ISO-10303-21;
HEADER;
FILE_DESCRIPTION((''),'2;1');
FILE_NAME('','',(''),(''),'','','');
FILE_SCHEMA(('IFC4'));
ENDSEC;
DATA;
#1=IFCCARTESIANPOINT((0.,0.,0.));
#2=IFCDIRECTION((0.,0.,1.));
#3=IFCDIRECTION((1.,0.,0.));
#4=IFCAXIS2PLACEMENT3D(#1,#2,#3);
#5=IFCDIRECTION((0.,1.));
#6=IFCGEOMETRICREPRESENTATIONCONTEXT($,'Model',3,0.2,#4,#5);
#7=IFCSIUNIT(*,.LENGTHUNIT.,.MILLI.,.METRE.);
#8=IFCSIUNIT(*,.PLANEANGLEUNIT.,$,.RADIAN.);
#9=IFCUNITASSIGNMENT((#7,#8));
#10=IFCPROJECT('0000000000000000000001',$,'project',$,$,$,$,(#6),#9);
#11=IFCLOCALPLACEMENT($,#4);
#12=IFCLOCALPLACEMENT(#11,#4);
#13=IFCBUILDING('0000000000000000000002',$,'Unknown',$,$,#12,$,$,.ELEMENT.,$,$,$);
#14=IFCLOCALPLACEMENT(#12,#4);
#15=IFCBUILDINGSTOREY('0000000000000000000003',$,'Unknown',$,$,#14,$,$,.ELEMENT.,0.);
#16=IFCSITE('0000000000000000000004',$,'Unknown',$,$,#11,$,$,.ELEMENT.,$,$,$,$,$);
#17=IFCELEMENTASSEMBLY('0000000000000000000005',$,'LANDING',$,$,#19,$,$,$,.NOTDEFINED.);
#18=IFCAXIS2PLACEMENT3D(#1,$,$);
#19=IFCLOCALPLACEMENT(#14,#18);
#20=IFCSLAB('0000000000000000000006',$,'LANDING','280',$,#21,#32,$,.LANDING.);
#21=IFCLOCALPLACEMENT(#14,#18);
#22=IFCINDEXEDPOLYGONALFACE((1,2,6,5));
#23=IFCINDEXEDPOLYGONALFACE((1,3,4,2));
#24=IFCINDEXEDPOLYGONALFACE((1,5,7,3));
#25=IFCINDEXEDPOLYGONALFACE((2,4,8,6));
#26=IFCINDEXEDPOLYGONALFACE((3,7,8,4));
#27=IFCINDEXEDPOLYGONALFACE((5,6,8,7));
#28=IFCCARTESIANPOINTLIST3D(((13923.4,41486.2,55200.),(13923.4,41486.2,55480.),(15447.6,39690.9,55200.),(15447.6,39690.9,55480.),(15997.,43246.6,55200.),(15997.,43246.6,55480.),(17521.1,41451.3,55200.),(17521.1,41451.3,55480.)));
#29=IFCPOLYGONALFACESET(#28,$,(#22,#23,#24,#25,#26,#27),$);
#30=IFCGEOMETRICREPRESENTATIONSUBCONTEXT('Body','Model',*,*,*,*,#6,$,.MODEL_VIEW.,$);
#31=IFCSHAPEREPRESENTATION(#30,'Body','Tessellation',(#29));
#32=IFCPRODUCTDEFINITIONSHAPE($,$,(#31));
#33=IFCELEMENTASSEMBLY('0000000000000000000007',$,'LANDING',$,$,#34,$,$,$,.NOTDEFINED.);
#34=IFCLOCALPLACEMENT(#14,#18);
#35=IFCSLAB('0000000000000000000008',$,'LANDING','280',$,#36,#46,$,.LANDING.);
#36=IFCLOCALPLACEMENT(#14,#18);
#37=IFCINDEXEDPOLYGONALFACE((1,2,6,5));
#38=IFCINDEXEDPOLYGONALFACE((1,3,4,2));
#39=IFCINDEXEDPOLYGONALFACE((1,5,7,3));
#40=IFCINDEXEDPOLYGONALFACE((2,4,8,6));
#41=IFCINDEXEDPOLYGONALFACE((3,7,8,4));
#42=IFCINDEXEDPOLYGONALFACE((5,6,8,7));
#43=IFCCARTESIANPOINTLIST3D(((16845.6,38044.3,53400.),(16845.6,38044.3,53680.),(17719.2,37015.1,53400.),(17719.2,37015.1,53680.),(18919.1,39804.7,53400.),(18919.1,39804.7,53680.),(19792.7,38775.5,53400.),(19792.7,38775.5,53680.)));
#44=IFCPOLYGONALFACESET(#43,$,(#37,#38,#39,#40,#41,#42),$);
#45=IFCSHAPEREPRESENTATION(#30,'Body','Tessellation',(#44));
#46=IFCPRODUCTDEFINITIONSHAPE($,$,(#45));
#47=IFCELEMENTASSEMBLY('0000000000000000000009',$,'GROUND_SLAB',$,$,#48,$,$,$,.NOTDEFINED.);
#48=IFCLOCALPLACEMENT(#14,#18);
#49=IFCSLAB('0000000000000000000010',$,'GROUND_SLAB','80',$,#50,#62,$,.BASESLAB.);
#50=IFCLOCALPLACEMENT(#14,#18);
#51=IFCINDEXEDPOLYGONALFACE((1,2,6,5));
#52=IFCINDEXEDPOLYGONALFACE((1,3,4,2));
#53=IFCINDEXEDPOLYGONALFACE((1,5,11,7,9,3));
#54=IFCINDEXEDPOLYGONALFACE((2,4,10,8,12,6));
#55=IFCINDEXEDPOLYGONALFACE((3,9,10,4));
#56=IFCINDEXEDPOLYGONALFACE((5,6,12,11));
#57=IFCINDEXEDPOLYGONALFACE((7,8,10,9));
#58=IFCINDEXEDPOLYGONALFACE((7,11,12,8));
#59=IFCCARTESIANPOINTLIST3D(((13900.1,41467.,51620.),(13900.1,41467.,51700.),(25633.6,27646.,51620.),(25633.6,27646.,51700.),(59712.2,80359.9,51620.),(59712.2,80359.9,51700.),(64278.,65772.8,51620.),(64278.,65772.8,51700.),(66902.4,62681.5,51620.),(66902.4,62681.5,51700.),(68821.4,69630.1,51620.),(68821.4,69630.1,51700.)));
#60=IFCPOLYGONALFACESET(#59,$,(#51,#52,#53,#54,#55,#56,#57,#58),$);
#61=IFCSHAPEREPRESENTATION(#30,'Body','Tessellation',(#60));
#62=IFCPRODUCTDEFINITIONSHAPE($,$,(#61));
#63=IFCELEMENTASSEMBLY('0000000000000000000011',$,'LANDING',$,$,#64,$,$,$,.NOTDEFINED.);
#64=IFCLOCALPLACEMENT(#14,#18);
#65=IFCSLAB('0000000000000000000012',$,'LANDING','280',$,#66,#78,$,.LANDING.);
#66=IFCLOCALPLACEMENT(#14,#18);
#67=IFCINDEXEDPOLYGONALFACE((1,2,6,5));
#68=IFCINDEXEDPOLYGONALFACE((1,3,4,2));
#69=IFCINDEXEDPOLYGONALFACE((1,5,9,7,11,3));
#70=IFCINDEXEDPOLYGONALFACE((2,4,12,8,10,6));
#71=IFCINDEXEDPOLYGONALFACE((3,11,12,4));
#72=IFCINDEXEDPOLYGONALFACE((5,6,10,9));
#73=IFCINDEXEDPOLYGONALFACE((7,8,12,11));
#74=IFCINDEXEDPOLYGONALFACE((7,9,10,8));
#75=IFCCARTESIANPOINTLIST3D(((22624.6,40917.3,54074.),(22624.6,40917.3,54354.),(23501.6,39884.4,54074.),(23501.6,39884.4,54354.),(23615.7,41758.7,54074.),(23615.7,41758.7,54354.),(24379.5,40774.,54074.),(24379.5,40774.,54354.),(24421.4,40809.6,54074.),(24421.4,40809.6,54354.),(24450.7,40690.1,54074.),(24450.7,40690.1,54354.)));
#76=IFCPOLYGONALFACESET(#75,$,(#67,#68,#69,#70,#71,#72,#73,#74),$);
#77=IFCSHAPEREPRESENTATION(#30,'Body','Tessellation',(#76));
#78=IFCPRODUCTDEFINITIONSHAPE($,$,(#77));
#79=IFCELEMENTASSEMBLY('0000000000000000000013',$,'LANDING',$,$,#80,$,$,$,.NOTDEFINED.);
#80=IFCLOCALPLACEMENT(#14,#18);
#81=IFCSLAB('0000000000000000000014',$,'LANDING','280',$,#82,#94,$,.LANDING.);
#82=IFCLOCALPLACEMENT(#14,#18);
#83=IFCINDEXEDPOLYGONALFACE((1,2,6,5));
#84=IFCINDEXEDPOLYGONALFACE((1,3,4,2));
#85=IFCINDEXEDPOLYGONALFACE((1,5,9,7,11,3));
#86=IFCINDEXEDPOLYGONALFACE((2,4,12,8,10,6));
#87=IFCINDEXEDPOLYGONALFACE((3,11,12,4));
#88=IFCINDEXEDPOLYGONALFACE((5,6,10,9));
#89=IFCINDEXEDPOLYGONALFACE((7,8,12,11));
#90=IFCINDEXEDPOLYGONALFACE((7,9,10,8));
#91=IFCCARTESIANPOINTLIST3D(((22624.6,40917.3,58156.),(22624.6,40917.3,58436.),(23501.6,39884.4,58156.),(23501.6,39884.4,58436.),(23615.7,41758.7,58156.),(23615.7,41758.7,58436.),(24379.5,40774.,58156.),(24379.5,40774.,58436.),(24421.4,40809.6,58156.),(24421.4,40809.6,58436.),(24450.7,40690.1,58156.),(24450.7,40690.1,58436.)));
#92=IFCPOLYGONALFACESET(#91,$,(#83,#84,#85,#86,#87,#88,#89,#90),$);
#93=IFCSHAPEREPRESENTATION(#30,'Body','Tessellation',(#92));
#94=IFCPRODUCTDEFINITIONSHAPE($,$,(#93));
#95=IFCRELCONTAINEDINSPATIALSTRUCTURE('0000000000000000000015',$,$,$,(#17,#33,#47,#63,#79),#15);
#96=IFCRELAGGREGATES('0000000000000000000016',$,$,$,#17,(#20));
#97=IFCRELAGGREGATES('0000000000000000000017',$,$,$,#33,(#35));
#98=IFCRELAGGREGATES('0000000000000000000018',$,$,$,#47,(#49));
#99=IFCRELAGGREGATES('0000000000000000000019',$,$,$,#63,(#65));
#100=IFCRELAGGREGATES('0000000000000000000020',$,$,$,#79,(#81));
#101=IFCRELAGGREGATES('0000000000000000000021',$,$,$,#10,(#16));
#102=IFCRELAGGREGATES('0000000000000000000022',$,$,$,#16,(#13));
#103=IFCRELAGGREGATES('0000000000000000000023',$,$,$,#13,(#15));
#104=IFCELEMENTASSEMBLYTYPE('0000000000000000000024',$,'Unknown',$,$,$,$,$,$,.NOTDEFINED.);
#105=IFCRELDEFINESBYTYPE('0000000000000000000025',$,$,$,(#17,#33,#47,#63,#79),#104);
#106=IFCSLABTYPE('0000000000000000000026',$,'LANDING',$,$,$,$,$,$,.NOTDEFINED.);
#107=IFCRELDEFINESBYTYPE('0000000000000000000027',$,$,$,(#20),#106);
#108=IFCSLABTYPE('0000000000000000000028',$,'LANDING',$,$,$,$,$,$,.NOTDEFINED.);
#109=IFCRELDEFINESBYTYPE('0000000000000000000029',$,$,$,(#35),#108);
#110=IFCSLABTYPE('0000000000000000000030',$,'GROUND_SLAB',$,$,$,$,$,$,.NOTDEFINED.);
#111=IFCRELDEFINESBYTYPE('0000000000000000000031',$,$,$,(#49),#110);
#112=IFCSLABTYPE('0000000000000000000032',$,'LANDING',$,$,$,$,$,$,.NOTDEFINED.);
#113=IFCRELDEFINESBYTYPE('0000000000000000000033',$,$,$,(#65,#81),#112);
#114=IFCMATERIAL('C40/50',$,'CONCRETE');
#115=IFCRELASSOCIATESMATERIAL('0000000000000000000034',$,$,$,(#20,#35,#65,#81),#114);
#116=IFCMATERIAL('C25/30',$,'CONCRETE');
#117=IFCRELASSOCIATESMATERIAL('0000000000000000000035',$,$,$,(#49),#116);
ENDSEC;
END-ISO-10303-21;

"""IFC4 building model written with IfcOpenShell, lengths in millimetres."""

from ifc_helpers import new_model, si_unit, direction, frame, origin_with_axes, place, context, subcontext, project, spatial, line, indexed_curve, outline, extrude, material, material_profile, profile_set, profile_usage, type_object, element, aggregate, save


model = new_model("IFC4")

# Units and contexts
model_context = context("Model", 3, precision=0.2, world=origin_with_axes(), true_north=direction((0.0, 1.0)))
body_context = subcontext(model_context, "Body", "Model", "MODEL_VIEW")
ifc_project = project(units=[si_unit("LENGTHUNIT", "METRE", prefix="MILLI"), si_unit("PLANEANGLEUNIT", "RADIAN")], contexts=[model_context])

# Site, building, storey
site_placement = place(None, origin_with_axes())
site = spatial("IfcSite", under=ifc_project, at=site_placement, Name="Unknown", CompositionType="ELEMENT")
building_placement = place(site_placement, origin_with_axes())
building = spatial("IfcBuilding", under=site, at=building_placement, Name="Unknown", CompositionType="ELEMENT")
storey_placement = place(building_placement, origin_with_axes())
storey = spatial("IfcBuildingStorey", under=building, at=storey_placement, Name="Unknown", CompositionType="ELEMENT", Elevation=0.0)

# Shared definitions
element_assembly_type = type_object("IfcElementAssemblyType", Name="Unknown", PredefinedType="NOTDEFINED")
ifc_material_1 = material(Name="C40/50", Category="CONCRETE")

# Element assemblies, slabs
assembly_1_placement = place(storey_placement, frame((17521.1, 41451.3, 55340.0), z_axis=(0.0, 0.0, 1.0), x_axis=(-0.64719, 0.762329, 0.0)))
assembly_1 = element("IfcElementAssembly", 1, at=assembly_1_placement, inside=storey, type_object=element_assembly_type, Name="LANDING", PredefinedType="NOTDEFINED")
ifc_material_profile_1 = material_profile(ifc_material_1, outline(indexed_curve([(0.0, 0.0), (2355.0, 0.0), (2355.0, 2720.0), (0.0, 2720.0)], segments=[line(1, 2, 3, 4, 1)])), Name="280")
ifc_profile_set_1 = profile_set([ifc_material_profile_1])
ifc_profile_usage_1 = profile_usage(ifc_profile_set_1, cardinal=8)
slab_type_1 = type_object("IfcSlabType", Name="LANDING")
slab_1_placement = place(assembly_1_placement, origin_with_axes())
slab_1 = element("IfcSlab", 2, at=slab_1_placement, type_object=slab_type_1, material=ifc_profile_usage_1, Name="LANDING", Description="280", PredefinedType="LANDING", context=body_context, shape_type="SolidModel", body=[
    extrude(outline(indexed_curve([(0.0, 0.0), (2355.0, 0.0), (2355.0, 2720.0), (0.0, 2720.0)], segments=[line(1, 2, 3, 4, 1)])), frame((0.0, 0.0, 140.0), z_axis=(0.0, 0.0, 1.0), x_axis=(1.0, 0.0, 0.0)), (0.0, 0.0, -1.0), 280.0),
])
aggregate(assembly_1, [slab_1])
assembly_2_placement = place(storey_placement, frame((17719.2, 37015.1, 53540.0), z_axis=(0.0, 0.0, 1.0), x_axis=(0.762329, 0.64719, 0.0)))
assembly_2 = element("IfcElementAssembly", 3, at=assembly_2_placement, inside=storey, type_object=element_assembly_type, Name="LANDING", PredefinedType="NOTDEFINED")
ifc_material_profile_2 = material_profile(ifc_material_1, outline(indexed_curve([(0.0, 0.0), (2720.0, 0.0), (2720.1, 1350.0), (0.1, 1350.0)], segments=[line(1, 2, 3, 4, 1)])), Name="280")
ifc_profile_set_2 = profile_set([ifc_material_profile_2])
ifc_profile_usage_2 = profile_usage(ifc_profile_set_2, cardinal=8)
slab_type_2 = type_object("IfcSlabType", Name="LANDING")
slab_2_placement = place(assembly_2_placement, origin_with_axes())
slab_2 = element("IfcSlab", 4, at=slab_2_placement, type_object=slab_type_2, material=ifc_profile_usage_2, Name="LANDING", Description="280", PredefinedType="LANDING", context=body_context, shape_type="SolidModel", body=[
    extrude(outline(indexed_curve([(0.0, 0.0), (2720.0, 0.0), (2720.1, 1350.0), (0.1, 1350.0)], segments=[line(1, 2, 3, 4, 1)])), frame((0.0, 0.0, 140.0), z_axis=(0.0, 0.0, 1.0), x_axis=(1.0, 0.0, 0.0)), (0.0, 0.0, -1.0), 280.0),
])
aggregate(assembly_2, [slab_2])
assembly_3_placement = place(storey_placement, frame((13900.1, 41467.0, 51660.0), z_axis=(0.0, 0.0, 1.0), x_axis=(0.64719, -0.762329, 0.0)))
assembly_3 = element("IfcElementAssembly", 5, at=assembly_3_placement, inside=storey, type_object=element_assembly_type, Name="GROUND_SLAB", PredefinedType="NOTDEFINED")
ifc_material_2 = material(Name="C25/30", Category="CONCRETE")
ifc_material_profile_3 = material_profile(ifc_material_2, outline(indexed_curve([(0.0, 0.0), (18130.0, 0.0), (18130.1, 54135.0), (14075.1, 54135.0), (14075.0, 60095.0), (0.0, 60095.0)], segments=[line(1, 2, 3, 4, 5, 6, 1)])), Name="80")
ifc_profile_set_3 = profile_set([ifc_material_profile_3])
ifc_profile_usage_3 = profile_usage(ifc_profile_set_3, cardinal=8)
slab_type_3 = type_object("IfcSlabType", Name="GROUND_SLAB")
slab_3_placement = place(assembly_3_placement, origin_with_axes())
slab_3 = element("IfcSlab", 6, at=slab_3_placement, type_object=slab_type_3, material=ifc_profile_usage_3, Name="GROUND_SLAB", Description="80", PredefinedType="BASESLAB", context=body_context, shape_type="SolidModel", body=[
    extrude(outline(indexed_curve([(0.0, 0.0), (18130.0, 0.0), (18130.1, 54135.0), (14075.1, 54135.0), (14075.0, 60095.0), (0.0, 60095.0)], segments=[line(1, 2, 3, 4, 5, 6, 1)])), frame((0.0, 0.0, 40.0), z_axis=(0.0, 0.0, 1.0), x_axis=(1.0, 0.0, 0.0)), (0.0, 0.0, -1.0), 80.0),
])
aggregate(assembly_3, [slab_3])
assembly_4_placement = place(storey_placement, frame((23615.7, 41758.7, 54214.0), z_axis=(0.0, 0.0, 1.0), x_axis=(-0.762329, -0.64719, 0.0)))
assembly_4 = element("IfcElementAssembly", 7, at=assembly_4_placement, inside=storey, type_object=element_assembly_type, Name="LANDING", PredefinedType="NOTDEFINED")
ifc_material_profile_4 = material_profile(ifc_material_1, outline(indexed_curve([(0.0, 0.0), (1300.0, 0.0), (1300.0, 1355.0), (55.0, 1355.0), (55.0, 1245.0), (0.0, 1245.0)], segments=[line(1, 2, 3, 4, 5, 6, 1)])), Name="280")
ifc_profile_set_4 = profile_set([ifc_material_profile_4])
ifc_profile_usage_4 = profile_usage(ifc_profile_set_4, cardinal=8)
slab_type_4 = type_object("IfcSlabType", Name="LANDING")
slab_4_placement = place(assembly_4_placement, origin_with_axes())
slab_4 = element("IfcSlab", 8, at=slab_4_placement, type_object=slab_type_4, material=ifc_profile_usage_4, Name="LANDING", Description="280", PredefinedType="LANDING", context=body_context, shape_type="SolidModel", body=[
    extrude(outline(indexed_curve([(0.0, 0.0), (1300.0, 0.0), (1300.0, 1355.0), (55.0, 1355.0), (55.0, 1245.0), (0.0, 1245.0)], segments=[line(1, 2, 3, 4, 5, 6, 1)])), frame((0.0, 0.0, 140.0), z_axis=(0.0, 0.0, 1.0), x_axis=(1.0, 0.0, 0.0)), (0.0, 0.0, -1.0), 280.0),
])
aggregate(assembly_4, [slab_4])
assembly_5_placement = place(storey_placement, frame((23615.7, 41758.7, 58296.0), z_axis=(0.0, 0.0, 1.0), x_axis=(-0.762329, -0.64719, 0.0)))
assembly_5 = element("IfcElementAssembly", 9, at=assembly_5_placement, inside=storey, type_object=element_assembly_type, Name="LANDING", PredefinedType="NOTDEFINED")
slab_5_placement = place(assembly_5_placement, origin_with_axes())
slab_5 = element("IfcSlab", 10, at=slab_5_placement, type_object=slab_type_4, material=ifc_profile_usage_4, Name="LANDING", Description="280", PredefinedType="LANDING", context=body_context, shape_type="SolidModel", body=[
    extrude(outline(indexed_curve([(0.0, 0.0), (1300.0, 0.0), (1300.0, 1355.0), (55.0, 1355.0), (55.0, 1245.0), (0.0, 1245.0)], segments=[line(1, 2, 3, 4, 5, 6, 1)])), frame((0.0, 0.0, 140.0), z_axis=(0.0, 0.0, 1.0), x_axis=(1.0, 0.0, 0.0)), (0.0, 0.0, -1.0), 280.0),
])
aggregate(assembly_5, [slab_5])

save(model, "model.ifc")
